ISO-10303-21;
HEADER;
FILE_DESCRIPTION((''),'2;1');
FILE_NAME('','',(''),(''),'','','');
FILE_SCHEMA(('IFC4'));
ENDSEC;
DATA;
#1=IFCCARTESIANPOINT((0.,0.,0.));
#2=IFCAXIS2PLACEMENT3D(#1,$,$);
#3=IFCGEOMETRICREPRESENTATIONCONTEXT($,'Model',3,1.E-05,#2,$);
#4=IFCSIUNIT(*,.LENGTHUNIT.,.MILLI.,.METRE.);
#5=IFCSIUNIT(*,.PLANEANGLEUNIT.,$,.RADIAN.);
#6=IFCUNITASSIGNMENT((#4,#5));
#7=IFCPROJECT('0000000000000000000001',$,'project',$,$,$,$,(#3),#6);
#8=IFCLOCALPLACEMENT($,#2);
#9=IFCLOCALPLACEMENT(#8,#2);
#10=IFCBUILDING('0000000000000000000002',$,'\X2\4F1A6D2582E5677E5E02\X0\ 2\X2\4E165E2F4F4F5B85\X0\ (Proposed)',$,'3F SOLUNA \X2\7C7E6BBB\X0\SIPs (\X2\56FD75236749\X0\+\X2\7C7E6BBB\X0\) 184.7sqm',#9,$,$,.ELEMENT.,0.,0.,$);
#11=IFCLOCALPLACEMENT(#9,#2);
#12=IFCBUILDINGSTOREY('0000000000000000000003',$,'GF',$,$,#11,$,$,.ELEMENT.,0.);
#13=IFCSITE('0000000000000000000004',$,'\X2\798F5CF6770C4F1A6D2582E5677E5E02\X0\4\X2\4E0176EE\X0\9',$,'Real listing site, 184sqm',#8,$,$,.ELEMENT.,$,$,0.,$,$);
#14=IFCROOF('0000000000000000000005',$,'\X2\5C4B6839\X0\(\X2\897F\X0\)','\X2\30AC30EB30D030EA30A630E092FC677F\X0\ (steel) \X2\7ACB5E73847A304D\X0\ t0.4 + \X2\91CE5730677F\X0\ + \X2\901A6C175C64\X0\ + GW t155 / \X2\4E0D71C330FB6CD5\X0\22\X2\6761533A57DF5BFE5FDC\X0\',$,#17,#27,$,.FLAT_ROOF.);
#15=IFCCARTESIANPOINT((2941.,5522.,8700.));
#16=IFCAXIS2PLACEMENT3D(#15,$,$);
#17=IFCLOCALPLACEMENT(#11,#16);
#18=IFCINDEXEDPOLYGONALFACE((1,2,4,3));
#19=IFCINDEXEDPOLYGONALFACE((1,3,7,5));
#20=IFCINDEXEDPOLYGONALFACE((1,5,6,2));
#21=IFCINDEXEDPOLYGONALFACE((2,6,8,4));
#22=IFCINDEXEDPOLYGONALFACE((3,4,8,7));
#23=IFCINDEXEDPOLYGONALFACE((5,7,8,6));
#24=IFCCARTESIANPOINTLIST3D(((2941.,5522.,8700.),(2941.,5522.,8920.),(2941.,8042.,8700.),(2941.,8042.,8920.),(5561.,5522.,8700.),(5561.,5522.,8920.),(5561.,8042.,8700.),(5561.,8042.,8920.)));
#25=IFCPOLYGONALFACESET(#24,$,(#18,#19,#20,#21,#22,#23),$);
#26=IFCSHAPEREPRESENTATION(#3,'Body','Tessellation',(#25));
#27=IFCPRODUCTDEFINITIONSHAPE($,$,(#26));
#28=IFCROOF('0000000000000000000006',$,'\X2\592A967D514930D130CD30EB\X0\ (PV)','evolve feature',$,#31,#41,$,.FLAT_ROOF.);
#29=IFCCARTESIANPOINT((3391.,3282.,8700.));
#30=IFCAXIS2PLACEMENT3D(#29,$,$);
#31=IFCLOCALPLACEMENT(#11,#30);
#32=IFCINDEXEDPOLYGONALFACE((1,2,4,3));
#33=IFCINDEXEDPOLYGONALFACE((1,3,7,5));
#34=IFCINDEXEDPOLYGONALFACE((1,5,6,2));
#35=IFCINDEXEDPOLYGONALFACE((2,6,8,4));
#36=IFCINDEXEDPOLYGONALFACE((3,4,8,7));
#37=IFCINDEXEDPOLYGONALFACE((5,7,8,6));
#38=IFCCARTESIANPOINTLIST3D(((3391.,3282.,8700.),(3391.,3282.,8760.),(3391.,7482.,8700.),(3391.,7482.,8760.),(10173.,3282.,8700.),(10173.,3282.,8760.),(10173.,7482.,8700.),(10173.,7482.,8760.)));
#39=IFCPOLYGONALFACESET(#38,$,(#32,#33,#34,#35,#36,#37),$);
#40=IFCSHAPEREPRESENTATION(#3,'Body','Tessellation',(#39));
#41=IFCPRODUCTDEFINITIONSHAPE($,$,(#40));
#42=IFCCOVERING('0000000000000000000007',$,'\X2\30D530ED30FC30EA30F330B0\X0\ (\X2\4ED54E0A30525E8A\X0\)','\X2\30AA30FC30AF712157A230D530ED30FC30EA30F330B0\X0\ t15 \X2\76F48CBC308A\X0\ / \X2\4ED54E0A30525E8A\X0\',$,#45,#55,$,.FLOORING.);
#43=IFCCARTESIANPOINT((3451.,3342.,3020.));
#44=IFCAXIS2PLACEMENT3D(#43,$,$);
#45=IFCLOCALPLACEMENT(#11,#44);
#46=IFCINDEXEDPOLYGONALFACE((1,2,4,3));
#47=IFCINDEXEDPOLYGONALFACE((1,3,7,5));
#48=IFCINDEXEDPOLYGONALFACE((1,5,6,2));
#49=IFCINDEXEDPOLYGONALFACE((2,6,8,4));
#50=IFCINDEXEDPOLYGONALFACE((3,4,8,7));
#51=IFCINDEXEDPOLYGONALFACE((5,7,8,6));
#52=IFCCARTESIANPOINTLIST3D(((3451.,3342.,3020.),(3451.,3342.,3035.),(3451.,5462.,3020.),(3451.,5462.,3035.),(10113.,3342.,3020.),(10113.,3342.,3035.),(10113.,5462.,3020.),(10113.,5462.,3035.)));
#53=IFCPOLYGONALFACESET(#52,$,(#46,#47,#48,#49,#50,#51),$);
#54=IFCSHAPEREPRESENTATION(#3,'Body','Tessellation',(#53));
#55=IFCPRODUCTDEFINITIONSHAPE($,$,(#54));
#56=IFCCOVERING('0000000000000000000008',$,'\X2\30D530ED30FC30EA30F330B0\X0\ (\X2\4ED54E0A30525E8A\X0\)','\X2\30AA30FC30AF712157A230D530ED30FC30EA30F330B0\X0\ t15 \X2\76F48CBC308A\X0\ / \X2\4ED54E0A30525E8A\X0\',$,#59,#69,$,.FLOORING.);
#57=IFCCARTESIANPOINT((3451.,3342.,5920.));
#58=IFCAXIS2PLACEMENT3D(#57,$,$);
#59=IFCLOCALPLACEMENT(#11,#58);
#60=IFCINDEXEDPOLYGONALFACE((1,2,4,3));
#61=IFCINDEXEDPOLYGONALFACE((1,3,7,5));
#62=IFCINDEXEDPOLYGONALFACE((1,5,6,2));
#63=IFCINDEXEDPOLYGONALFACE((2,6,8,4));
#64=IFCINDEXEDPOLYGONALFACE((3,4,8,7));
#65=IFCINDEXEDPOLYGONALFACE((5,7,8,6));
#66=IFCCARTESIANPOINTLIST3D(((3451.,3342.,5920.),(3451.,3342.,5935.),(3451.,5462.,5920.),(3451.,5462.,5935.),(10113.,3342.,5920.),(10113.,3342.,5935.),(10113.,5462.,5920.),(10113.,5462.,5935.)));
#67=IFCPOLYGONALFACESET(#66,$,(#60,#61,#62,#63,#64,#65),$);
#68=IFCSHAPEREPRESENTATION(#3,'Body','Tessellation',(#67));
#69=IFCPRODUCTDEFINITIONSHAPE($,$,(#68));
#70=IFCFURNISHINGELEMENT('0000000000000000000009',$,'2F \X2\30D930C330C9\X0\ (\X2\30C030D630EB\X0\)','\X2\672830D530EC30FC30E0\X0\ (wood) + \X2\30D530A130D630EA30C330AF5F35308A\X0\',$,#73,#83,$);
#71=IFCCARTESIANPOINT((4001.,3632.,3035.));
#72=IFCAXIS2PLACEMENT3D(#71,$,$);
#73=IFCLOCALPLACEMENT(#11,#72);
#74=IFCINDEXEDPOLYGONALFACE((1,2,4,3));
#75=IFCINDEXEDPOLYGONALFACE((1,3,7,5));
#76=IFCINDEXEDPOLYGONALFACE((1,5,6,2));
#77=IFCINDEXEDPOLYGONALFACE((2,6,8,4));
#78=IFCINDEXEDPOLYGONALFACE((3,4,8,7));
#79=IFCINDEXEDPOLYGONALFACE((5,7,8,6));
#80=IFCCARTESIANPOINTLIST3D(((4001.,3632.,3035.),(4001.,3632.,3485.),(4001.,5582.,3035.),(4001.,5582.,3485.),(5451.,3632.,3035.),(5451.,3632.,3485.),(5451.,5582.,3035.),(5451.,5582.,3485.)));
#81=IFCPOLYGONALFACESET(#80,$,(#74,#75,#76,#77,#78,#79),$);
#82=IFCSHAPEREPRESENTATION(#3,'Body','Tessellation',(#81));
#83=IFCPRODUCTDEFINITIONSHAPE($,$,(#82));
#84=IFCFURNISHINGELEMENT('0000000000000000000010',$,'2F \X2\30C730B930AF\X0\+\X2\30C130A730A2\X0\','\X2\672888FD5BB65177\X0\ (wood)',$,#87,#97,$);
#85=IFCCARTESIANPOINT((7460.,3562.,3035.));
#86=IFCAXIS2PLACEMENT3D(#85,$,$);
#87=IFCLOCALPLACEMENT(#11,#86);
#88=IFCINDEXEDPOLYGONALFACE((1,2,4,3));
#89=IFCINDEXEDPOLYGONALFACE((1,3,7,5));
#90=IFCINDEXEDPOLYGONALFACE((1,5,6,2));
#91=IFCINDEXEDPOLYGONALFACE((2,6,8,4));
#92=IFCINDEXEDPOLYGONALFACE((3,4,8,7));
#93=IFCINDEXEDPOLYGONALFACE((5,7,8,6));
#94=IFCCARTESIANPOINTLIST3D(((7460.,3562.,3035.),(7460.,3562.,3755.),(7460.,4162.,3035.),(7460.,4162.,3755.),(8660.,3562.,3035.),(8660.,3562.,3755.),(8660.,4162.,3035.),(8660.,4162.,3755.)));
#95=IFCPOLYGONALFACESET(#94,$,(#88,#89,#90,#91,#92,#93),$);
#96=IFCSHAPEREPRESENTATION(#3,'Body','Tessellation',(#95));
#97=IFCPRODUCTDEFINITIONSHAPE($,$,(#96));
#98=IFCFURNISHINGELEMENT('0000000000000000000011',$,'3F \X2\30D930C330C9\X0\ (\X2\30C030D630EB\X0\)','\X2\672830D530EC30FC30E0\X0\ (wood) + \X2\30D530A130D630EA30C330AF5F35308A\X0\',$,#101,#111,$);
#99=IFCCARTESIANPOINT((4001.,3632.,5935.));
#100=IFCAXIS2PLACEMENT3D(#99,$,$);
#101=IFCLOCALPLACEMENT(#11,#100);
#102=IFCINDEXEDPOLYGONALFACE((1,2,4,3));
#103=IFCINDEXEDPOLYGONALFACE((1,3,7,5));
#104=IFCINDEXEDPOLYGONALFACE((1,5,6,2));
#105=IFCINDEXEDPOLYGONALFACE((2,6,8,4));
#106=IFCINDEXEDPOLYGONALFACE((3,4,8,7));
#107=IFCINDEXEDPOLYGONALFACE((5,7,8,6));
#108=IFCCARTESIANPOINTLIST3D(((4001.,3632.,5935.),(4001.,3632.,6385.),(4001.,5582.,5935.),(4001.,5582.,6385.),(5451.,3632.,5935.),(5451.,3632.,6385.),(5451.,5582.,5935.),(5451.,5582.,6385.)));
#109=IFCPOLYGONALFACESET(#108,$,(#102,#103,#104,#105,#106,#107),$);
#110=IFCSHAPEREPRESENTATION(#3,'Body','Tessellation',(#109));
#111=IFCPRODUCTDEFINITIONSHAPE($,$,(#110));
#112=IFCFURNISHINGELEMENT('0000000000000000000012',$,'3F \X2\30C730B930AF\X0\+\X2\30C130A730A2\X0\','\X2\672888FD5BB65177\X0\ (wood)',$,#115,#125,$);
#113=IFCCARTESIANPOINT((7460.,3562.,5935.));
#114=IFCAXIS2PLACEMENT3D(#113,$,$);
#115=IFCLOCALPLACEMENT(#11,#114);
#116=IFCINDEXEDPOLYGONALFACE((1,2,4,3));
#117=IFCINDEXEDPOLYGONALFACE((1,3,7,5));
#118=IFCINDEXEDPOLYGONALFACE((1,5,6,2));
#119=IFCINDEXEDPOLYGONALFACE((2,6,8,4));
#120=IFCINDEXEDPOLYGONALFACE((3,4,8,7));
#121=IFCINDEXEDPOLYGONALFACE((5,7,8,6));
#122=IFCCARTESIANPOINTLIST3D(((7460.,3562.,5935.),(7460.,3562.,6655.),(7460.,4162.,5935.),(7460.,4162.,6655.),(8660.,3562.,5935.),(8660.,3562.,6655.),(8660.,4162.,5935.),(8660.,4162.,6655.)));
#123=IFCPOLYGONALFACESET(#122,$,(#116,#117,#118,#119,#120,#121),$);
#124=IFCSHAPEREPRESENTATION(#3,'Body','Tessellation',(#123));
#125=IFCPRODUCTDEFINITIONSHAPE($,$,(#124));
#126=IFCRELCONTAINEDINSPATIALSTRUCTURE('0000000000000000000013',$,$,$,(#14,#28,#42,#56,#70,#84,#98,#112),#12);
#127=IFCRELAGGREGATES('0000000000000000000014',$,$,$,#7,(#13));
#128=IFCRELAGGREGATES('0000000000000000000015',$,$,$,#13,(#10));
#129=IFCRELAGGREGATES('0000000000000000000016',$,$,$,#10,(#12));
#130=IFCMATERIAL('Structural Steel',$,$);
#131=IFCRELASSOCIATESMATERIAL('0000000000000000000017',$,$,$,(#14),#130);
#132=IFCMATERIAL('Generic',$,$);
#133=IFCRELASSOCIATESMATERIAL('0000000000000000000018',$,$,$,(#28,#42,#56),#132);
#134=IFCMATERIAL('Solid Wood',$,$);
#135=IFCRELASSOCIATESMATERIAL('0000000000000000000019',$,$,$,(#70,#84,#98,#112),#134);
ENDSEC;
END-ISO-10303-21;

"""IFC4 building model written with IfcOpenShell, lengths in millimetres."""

from ifc_helpers import new_model, si_unit, frame, frame_2d, origin, place, context, project, spatial, rectangle, extrude, material, element, save


model = new_model("IFC4")

# Units and contexts
model_context = context("Model", 3, precision=1e-05, world=origin())
ifc_project = project(units=[si_unit("LENGTHUNIT", "METRE", prefix="MILLI"), si_unit("PLANEANGLEUNIT", "RADIAN")], contexts=[model_context])

# Site, building, storey
site_placement = place(None, origin())
site = spatial("IfcSite", under=ifc_project, at=site_placement, Name="福島県会津若松市4丁目9", ObjectType="Real listing site, 184sqm", CompositionType="ELEMENT", RefElevation=0.0)
building_placement = place(site_placement, origin())
building = spatial("IfcBuilding", under=site, at=building_placement, Name="会津若松市 2世帯住宅 (Proposed)", ObjectType="3F SOLUNA 籾殻SIPs (国産杉+籾殻) 184.7sqm", CompositionType="ELEMENT", ElevationOfRefHeight=0.0, ElevationOfTerrain=0.0)
storey_placement = place(building_placement, origin())
storey = spatial("IfcBuildingStorey", under=building, at=storey_placement, Name="GF", CompositionType="ELEMENT", Elevation=0.0)

# Shared definitions
ifc_material_1 = material(Name="Solid Wood")

# Roofs
ifc_material_2 = material(Name="Structural Steel")
roof_1_placement = place(storey_placement, frame((2941.0, 5522.0, 8700.0)))
element("IfcRoof", 1, at=roof_1_placement, inside=storey, material=ifc_material_2, Name="屋根(西)", Description="ガルバリウム鋼板 (steel) 立平葺き t0.4 + 野地板 + 通気層 + GW t155 / 不燃・法22条区域対応", PredefinedType="FLAT_ROOF", context=model_context, shape_type="SweptSolid", body=[
    extrude(rectangle(XDim=2620.0, YDim=2520.0, at=frame_2d((1310.0, 1260.0))), frame((2941.0, 5522.0, 8700.0)), (0.0, 0.0, 1.0), 220.0),
])
ifc_material_3 = material(Name="Generic")
roof_2_placement = place(storey_placement, frame((3391.0, 3282.0, 8700.0)))
element("IfcRoof", 2, at=roof_2_placement, inside=storey, material=ifc_material_3, Name="太陽光パネル (PV)", Description="evolve feature", PredefinedType="FLAT_ROOF", context=model_context, shape_type="SweptSolid", body=[
    extrude(rectangle(XDim=6782.0, YDim=4200.0, at=frame_2d((3391.0, 2100.0))), frame((3391.0, 3282.0, 8700.0)), (0.0, 0.0, 1.0), 60.0),
])

# Coverings
covering_1_placement = place(storey_placement, frame((3451.0, 3342.0, 3020.0)))
element("IfcCovering", 3, at=covering_1_placement, inside=storey, material=ifc_material_3, Name="フローリング (仕上げ床)", Description="オーク無垢フローリング t15 直貼り / 仕上げ床", PredefinedType="FLOORING", context=model_context, shape_type="SweptSolid", body=[
    extrude(rectangle(XDim=6662.0, YDim=2120.0, at=frame_2d((3331.0, 1060.0))), frame((3451.0, 3342.0, 3020.0)), (0.0, 0.0, 1.0), 15.0),
])
covering_2_placement = place(storey_placement, frame((3451.0, 3342.0, 5920.0)))
element("IfcCovering", 4, at=covering_2_placement, inside=storey, material=ifc_material_3, Name="フローリング (仕上げ床)", Description="オーク無垢フローリング t15 直貼り / 仕上げ床", PredefinedType="FLOORING", context=model_context, shape_type="SweptSolid", body=[
    extrude(rectangle(XDim=6662.0, YDim=2120.0, at=frame_2d((3331.0, 1060.0))), frame((3451.0, 3342.0, 5920.0)), (0.0, 0.0, 1.0), 15.0),
])

# Furnishing elements
furnishing_1_placement = place(storey_placement, frame((4001.0, 3632.0, 3035.0)))
element("IfcFurnishingElement", 5, at=furnishing_1_placement, inside=storey, material=ifc_material_1, Name="2F ベッド (ダブル)", Description="木フレーム (wood) + ファブリック張り", context=model_context, shape_type="SweptSolid", body=[
    extrude(rectangle(XDim=1450.0, YDim=1950.0, at=frame_2d((725.0, 975.0))), frame((4001.0, 3632.0, 3035.0)), (0.0, 0.0, 1.0), 450.0),
])
furnishing_2_placement = place(storey_placement, frame((7460.0, 3562.0, 3035.0)))
element("IfcFurnishingElement", 6, at=furnishing_2_placement, inside=storey, material=ifc_material_1, Name="2F デスク+チェア", Description="木製家具 (wood)", context=model_context, shape_type="SweptSolid", body=[
    extrude(rectangle(XDim=1200.0, YDim=600.0, at=frame_2d((600.0, 300.0))), frame((7460.0, 3562.0, 3035.0)), (0.0, 0.0, 1.0), 720.0),
])
furnishing_3_placement = place(storey_placement, frame((4001.0, 3632.0, 5935.0)))
element("IfcFurnishingElement", 7, at=furnishing_3_placement, inside=storey, material=ifc_material_1, Name="3F ベッド (ダブル)", Description="木フレーム (wood) + ファブリック張り", context=model_context, shape_type="SweptSolid", body=[
    extrude(rectangle(XDim=1450.0, YDim=1950.0, at=frame_2d((725.0, 975.0))), frame((4001.0, 3632.0, 5935.0)), (0.0, 0.0, 1.0), 450.0),
])
furnishing_4_placement = place(storey_placement, frame((7460.0, 3562.0, 5935.0)))
element("IfcFurnishingElement", 8, at=furnishing_4_placement, inside=storey, material=ifc_material_1, Name="3F デスク+チェア", Description="木製家具 (wood)", context=model_context, shape_type="SweptSolid", body=[
    extrude(rectangle(XDim=1200.0, YDim=600.0, at=frame_2d((600.0, 300.0))), frame((7460.0, 3562.0, 5935.0)), (0.0, 0.0, 1.0), 720.0),
])

save(model, "model.ifc")
